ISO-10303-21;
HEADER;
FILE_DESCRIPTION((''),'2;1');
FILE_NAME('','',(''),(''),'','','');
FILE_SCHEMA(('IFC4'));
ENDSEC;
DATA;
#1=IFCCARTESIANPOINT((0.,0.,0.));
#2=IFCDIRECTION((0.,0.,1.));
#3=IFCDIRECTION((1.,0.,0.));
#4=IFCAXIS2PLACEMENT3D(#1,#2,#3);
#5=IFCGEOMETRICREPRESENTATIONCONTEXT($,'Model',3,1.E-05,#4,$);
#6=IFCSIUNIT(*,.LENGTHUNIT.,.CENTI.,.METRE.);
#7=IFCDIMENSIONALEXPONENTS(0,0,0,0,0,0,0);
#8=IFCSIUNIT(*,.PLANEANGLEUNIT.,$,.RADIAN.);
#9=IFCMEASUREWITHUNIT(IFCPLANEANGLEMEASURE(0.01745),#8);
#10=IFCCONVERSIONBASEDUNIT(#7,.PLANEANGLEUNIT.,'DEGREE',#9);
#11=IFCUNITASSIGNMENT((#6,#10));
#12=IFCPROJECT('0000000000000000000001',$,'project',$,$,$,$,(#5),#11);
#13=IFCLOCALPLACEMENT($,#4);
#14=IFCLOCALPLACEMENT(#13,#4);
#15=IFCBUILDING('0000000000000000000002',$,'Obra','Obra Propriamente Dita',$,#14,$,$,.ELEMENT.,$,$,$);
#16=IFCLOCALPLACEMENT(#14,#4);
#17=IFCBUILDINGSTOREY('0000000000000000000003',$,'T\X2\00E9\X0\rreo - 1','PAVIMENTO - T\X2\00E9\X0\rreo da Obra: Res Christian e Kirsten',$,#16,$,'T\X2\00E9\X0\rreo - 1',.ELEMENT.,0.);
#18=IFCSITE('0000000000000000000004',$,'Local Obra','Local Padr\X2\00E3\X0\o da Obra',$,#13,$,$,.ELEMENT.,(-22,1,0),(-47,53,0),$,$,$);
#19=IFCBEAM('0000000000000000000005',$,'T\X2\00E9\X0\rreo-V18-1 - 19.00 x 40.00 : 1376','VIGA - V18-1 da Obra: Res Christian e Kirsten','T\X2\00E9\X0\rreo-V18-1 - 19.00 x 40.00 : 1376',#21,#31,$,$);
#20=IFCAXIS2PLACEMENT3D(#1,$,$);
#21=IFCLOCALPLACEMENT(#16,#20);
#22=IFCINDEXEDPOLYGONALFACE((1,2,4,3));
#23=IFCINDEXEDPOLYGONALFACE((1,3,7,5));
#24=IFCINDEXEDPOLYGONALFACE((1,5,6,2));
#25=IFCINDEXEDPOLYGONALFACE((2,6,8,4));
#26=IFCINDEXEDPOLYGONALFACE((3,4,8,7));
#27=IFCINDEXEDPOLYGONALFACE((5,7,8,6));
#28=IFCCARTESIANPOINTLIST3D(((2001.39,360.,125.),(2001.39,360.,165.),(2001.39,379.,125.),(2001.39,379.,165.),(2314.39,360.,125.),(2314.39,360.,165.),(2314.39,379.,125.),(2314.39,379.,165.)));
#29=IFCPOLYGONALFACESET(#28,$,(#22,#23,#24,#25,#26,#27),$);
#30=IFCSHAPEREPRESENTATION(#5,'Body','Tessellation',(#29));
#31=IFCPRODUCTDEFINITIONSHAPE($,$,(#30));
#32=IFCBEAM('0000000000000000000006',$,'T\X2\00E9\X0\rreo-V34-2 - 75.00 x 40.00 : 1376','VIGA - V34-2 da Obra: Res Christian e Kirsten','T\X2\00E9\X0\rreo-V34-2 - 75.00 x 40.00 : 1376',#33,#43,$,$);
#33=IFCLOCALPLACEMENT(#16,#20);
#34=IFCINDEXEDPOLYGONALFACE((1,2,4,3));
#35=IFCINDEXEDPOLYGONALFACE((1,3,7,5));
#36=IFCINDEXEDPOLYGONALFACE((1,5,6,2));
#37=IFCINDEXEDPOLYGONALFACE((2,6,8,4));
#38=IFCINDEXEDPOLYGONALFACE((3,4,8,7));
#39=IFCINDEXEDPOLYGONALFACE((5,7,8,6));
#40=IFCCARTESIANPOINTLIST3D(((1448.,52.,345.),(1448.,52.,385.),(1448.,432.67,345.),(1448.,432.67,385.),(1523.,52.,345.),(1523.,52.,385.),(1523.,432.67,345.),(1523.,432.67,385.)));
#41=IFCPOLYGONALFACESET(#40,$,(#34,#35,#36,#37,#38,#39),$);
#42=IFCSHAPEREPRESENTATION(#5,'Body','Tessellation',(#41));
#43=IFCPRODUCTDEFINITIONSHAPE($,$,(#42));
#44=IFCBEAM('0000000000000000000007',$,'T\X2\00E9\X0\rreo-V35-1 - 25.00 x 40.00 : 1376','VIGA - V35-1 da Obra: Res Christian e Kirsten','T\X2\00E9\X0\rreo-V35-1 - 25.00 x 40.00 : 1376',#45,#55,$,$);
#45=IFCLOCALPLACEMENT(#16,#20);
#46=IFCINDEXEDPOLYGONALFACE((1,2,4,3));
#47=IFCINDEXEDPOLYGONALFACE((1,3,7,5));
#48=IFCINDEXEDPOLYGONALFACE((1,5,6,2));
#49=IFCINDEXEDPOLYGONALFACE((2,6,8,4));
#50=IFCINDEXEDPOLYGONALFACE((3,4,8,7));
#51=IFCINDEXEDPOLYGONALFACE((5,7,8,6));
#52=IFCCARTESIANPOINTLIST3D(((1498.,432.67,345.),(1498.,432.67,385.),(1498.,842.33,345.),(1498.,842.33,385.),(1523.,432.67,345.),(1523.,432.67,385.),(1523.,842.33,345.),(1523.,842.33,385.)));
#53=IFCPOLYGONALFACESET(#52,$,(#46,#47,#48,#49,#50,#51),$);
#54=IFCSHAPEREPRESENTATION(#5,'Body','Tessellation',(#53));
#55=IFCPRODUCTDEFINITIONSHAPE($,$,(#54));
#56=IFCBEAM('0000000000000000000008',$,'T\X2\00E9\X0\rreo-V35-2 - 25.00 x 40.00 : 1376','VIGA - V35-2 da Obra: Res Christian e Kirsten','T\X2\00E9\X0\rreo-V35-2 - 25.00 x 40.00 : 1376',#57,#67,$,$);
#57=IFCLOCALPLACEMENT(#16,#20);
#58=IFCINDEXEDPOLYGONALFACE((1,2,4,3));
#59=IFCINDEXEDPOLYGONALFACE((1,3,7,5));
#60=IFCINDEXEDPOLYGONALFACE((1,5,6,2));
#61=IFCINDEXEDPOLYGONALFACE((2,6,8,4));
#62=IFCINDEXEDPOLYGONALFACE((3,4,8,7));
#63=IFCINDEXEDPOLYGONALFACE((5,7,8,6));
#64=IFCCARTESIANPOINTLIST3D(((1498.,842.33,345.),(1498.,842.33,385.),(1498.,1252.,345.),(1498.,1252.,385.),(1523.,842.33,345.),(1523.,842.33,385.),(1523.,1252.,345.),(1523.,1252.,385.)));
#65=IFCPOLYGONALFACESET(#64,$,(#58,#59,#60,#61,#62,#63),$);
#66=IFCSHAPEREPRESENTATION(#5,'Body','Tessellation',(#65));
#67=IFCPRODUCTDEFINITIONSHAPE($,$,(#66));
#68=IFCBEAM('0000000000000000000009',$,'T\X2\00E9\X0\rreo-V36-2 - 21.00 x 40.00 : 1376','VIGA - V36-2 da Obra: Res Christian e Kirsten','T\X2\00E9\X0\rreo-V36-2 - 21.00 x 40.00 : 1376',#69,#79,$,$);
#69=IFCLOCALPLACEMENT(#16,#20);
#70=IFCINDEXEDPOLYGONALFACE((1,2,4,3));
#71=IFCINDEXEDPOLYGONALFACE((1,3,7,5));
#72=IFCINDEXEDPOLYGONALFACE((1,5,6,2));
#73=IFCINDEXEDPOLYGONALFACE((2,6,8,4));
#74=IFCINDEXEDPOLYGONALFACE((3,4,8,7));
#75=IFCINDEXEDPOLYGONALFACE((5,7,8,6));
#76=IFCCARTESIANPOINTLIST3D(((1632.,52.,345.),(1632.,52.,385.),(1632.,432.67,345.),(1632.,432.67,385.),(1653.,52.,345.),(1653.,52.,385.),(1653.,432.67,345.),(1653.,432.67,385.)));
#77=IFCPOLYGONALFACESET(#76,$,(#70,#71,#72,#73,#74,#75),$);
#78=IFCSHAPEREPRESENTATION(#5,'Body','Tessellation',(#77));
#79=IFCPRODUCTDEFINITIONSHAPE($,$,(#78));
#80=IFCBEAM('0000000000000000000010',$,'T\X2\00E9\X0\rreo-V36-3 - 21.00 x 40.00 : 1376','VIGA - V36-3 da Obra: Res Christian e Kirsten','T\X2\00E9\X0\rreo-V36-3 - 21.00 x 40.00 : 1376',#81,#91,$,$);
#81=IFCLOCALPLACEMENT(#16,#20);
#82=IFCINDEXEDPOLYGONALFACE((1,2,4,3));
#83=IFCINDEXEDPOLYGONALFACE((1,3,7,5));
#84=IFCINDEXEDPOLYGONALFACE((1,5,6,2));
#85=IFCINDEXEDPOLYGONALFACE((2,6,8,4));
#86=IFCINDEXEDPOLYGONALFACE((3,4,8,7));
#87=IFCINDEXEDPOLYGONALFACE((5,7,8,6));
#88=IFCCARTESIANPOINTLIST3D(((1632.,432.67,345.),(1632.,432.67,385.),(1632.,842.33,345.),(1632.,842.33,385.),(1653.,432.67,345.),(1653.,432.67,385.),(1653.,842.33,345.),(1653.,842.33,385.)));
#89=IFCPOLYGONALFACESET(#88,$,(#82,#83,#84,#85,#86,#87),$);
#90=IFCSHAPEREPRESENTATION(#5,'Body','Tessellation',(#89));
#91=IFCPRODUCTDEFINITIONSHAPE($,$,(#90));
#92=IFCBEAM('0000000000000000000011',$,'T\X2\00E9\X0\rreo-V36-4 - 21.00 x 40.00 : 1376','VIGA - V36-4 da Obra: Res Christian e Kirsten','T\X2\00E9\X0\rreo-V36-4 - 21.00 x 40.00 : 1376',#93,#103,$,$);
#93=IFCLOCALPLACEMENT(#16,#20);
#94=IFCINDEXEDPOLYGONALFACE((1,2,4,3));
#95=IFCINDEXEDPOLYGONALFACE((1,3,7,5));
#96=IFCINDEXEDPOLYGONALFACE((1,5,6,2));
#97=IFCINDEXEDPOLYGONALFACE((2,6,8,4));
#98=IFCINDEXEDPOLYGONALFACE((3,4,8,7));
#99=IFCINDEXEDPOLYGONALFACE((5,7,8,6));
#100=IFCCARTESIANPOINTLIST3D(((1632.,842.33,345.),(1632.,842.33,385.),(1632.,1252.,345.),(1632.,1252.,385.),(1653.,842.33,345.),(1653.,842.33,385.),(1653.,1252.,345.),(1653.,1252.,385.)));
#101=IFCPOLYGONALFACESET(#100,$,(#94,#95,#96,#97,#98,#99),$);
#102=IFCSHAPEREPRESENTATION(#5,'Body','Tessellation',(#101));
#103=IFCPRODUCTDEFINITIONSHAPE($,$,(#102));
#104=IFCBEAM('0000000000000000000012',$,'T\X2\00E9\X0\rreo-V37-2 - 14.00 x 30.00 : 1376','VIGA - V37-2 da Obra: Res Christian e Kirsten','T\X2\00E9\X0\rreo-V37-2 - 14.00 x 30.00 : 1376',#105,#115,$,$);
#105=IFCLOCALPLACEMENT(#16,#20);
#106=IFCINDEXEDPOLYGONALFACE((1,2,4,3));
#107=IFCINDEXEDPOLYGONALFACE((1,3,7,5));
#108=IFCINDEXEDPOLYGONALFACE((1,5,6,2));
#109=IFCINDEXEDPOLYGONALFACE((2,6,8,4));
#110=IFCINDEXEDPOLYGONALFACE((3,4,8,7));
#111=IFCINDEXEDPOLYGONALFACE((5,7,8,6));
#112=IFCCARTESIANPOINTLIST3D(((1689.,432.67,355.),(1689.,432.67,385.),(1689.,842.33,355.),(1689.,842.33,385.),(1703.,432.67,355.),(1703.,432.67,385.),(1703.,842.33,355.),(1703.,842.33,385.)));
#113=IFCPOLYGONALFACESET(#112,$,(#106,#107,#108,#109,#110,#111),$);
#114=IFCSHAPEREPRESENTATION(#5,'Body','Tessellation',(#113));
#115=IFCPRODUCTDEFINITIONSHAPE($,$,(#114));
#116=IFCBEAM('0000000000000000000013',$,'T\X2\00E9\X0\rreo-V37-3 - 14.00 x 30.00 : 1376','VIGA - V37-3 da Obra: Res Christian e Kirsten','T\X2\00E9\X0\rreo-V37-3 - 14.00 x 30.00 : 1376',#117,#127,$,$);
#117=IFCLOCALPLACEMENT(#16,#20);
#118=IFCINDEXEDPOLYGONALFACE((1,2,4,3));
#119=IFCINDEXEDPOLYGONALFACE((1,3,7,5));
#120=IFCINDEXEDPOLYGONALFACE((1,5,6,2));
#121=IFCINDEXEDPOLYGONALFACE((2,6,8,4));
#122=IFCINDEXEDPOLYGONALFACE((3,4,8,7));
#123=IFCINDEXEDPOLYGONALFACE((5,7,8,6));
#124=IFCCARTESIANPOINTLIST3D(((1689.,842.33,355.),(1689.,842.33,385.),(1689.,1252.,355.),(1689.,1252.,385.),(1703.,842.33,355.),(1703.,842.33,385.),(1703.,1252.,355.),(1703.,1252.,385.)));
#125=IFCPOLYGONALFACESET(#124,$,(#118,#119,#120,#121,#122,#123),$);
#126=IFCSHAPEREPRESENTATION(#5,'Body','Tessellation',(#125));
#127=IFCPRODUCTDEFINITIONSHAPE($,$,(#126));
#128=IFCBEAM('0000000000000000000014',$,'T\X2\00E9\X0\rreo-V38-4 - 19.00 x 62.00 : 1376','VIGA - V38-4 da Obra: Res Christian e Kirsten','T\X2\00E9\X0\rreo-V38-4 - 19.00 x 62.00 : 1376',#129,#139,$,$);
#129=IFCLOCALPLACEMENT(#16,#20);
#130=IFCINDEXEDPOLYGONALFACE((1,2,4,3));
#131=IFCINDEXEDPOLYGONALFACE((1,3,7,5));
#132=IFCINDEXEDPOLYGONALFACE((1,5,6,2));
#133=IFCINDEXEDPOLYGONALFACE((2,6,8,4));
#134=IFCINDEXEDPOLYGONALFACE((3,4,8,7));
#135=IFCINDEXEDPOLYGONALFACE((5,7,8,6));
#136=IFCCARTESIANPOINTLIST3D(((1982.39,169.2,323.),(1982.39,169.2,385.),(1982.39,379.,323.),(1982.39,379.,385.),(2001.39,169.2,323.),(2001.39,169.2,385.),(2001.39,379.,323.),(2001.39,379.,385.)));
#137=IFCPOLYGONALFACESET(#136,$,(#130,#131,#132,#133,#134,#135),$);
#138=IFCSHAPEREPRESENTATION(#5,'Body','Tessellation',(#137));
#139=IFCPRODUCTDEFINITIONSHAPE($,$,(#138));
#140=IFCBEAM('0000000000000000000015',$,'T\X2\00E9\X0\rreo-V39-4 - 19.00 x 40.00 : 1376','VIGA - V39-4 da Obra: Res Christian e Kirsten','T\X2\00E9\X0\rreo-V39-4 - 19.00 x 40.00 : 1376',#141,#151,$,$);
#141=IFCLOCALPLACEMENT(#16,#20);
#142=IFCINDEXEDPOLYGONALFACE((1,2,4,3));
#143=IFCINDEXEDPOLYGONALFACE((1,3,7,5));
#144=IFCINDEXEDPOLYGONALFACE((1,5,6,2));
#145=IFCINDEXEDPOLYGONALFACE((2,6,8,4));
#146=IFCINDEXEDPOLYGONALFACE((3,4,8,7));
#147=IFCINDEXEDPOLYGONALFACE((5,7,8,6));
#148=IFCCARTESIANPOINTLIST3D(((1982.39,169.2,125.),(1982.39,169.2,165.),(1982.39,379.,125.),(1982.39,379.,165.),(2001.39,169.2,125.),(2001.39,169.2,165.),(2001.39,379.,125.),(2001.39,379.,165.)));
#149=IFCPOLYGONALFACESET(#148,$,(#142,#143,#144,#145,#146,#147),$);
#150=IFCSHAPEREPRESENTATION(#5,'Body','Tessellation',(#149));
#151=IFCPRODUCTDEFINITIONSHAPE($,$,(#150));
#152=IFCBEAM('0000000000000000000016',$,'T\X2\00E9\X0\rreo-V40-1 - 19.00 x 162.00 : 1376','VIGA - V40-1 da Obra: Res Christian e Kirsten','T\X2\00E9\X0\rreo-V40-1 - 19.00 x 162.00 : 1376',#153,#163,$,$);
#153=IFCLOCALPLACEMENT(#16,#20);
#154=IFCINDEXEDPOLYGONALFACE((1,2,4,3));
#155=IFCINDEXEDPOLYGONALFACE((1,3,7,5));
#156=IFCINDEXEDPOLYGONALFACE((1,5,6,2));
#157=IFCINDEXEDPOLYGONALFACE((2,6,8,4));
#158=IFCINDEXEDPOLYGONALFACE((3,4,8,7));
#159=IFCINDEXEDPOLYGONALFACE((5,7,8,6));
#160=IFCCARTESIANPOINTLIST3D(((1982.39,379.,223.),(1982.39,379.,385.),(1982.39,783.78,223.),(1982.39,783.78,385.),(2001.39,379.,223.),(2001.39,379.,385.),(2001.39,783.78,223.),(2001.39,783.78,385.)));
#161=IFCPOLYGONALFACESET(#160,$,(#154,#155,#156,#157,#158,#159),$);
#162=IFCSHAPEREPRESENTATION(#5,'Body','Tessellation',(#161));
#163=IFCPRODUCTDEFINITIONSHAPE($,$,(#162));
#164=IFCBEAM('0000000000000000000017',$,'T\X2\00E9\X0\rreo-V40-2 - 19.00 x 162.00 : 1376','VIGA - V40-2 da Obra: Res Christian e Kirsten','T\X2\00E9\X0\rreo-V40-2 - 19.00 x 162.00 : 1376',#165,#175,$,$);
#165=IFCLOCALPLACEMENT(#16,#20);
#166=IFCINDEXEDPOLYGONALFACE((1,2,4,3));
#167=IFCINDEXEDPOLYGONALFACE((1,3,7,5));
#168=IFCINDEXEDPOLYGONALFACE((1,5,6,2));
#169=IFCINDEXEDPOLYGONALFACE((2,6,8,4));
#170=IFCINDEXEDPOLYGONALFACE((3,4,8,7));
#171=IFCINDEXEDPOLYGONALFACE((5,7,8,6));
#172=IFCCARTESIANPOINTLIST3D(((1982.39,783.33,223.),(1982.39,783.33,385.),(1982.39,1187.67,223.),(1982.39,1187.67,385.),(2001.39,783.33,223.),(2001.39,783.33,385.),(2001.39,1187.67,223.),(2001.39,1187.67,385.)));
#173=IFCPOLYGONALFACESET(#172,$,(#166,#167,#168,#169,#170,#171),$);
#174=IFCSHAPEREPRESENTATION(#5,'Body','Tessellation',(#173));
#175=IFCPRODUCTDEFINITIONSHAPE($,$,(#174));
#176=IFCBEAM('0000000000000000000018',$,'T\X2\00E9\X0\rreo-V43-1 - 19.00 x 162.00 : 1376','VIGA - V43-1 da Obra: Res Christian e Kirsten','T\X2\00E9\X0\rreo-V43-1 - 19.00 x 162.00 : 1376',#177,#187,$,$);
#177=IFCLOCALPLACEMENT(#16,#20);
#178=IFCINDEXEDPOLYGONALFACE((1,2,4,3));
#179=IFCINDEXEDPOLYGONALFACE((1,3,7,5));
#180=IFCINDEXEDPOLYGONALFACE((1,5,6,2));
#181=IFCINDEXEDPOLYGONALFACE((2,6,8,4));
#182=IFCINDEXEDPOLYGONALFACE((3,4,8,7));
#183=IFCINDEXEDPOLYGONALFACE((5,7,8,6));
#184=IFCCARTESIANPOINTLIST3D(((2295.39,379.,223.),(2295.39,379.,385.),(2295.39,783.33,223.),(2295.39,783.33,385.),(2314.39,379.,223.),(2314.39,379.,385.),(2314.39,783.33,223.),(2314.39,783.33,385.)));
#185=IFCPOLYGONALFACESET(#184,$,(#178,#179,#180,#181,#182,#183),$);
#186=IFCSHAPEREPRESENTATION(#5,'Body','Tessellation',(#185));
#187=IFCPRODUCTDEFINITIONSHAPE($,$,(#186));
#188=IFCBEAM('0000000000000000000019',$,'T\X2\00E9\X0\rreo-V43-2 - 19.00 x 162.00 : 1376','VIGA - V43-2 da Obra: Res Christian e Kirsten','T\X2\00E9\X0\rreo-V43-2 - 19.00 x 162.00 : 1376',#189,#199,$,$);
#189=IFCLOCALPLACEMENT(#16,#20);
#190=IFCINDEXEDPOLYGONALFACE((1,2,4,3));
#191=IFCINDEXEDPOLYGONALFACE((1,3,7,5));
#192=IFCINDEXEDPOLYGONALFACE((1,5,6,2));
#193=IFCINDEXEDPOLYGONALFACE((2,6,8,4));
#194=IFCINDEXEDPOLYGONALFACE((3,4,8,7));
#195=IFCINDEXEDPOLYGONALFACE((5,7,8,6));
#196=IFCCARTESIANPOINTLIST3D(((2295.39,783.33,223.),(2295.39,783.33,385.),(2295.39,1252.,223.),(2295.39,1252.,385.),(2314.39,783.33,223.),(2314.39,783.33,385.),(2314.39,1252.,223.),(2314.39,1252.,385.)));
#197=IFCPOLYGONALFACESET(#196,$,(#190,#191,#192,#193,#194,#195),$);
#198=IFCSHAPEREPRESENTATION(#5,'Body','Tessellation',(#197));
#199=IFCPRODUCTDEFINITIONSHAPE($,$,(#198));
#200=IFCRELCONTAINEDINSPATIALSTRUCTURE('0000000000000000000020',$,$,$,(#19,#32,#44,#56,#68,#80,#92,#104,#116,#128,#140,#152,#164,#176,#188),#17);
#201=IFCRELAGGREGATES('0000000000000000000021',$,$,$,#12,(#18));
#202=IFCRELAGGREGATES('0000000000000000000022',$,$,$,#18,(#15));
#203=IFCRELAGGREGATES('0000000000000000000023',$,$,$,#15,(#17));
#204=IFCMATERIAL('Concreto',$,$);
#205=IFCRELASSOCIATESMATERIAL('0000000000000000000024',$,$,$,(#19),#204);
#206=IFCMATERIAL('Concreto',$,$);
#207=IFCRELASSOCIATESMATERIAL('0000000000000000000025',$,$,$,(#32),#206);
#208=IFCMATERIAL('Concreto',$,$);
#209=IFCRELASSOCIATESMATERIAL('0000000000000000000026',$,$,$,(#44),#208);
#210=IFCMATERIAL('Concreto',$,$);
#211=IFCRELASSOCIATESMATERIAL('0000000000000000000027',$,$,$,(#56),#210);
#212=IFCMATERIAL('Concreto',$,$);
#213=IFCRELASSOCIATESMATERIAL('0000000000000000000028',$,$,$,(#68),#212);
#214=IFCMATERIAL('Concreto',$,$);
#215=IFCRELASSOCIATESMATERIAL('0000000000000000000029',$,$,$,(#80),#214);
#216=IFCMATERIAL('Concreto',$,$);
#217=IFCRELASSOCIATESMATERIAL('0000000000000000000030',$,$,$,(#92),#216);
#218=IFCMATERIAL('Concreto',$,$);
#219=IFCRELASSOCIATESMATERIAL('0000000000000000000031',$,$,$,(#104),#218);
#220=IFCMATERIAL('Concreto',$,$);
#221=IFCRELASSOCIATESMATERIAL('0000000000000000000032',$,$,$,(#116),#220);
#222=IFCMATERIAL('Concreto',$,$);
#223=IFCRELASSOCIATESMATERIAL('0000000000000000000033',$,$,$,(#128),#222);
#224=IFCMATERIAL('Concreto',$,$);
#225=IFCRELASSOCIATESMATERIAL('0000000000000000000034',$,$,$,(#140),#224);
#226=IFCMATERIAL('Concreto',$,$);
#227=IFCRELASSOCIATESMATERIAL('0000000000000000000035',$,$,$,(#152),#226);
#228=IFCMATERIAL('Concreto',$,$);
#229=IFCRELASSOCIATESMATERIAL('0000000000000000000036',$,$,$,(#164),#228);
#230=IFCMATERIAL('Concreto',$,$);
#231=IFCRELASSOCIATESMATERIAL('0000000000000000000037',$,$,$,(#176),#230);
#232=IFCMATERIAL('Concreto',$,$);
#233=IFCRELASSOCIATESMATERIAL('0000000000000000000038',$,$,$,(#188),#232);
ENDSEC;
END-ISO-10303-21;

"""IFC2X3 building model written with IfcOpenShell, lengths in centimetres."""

from ifc_helpers import new_model, entity, si_unit, converted_unit, frame, origin_with_axes, place, context, project, spatial, polyline, outline, extrude, material, element, save


model = new_model("IFC2X3")

# Units and contexts
model_context = context("Model", 3, precision=1e-05, world=origin_with_axes())
ifc_project = project(units=[si_unit("LENGTHUNIT", "METRE", prefix="CENTI"), converted_unit("PLANEANGLEUNIT", "DEGREE", entity("IfcPlaneAngleMeasure", 0.01745), si_unit("PLANEANGLEUNIT", "RADIAN"), dimensions=[0, 0, 0, 0, 0, 0, 0])], contexts=[model_context])

# Site, building, storey
site_placement = place(None, origin_with_axes())
site = spatial("IfcSite", under=ifc_project, at=site_placement, Name="Local Obra", Description="Local Padrão da Obra", CompositionType="ELEMENT", RefLatitude=(-22, 1, 0), RefLongitude=(-47, 53, 0))
building_placement = place(site_placement, origin_with_axes())
building = spatial("IfcBuilding", under=site, at=building_placement, Name="Obra", Description="Obra Propriamente Dita", CompositionType="ELEMENT")
storey_placement = place(building_placement, origin_with_axes())
storey = spatial("IfcBuildingStorey", under=building, at=storey_placement, Name="Térreo - 1", Description="PAVIMENTO - Térreo da Obra: Res Christian e Kirsten", LongName="Térreo - 1", CompositionType="ELEMENT", Elevation=0.0)

# Beams
ifc_material_1 = material(Name="Concreto")
beam_1_placement = place(storey_placement, frame((2001.39, 379.0, 165.0), z_axis=(1.0, 0.0, 0.0), x_axis=(0.0, -1.0, 0.0)))
element("IfcBeam", 1, at=beam_1_placement, inside=storey, material=ifc_material_1, Name="Térreo-V18-1 - 19.00 x 40.00 : 1376", Description="VIGA - V18-1 da Obra: Res Christian e Kirsten", ObjectType="Térreo-V18-1 - 19.00 x 40.00 : 1376", context=model_context, shape_type="SweptSolid", body=[
    extrude(outline(polyline([(0.0, 0.0), (19.0, 0.0), (19.0, 40.0), (0.0, 40.0), (0.0, 0.0)])), origin_with_axes(), (0.0, 0.0, 1.0), 313.0),
])
ifc_material_2 = material(Name="Concreto")
beam_2_placement = place(storey_placement, frame((1523.0, 52.0, 385.0), z_axis=(0.0, 1.0, 0.0), x_axis=(1.0, 0.0, 0.0)))
element("IfcBeam", 2, at=beam_2_placement, inside=storey, material=ifc_material_2, Name="Térreo-V34-2 - 75.00 x 40.00 : 1376", Description="VIGA - V34-2 da Obra: Res Christian e Kirsten", ObjectType="Térreo-V34-2 - 75.00 x 40.00 : 1376", context=model_context, shape_type="SweptSolid", body=[
    extrude(outline(polyline([(-75.0, 0.0), (0.0, 0.0), (0.0, 40.0), (-75.0, 40.0), (-75.0, 0.0)])), origin_with_axes(), (0.0, 0.0, 1.0), 380.67),
])
ifc_material_3 = material(Name="Concreto")
beam_3_placement = place(storey_placement, frame((1523.0, 432.67, 385.0), z_axis=(0.0, 1.0, 0.0), x_axis=(1.0, 0.0, 0.0)))
element("IfcBeam", 3, at=beam_3_placement, inside=storey, material=ifc_material_3, Name="Térreo-V35-1 - 25.00 x 40.00 : 1376", Description="VIGA - V35-1 da Obra: Res Christian e Kirsten", ObjectType="Térreo-V35-1 - 25.00 x 40.00 : 1376", context=model_context, shape_type="SweptSolid", body=[
    extrude(outline(polyline([(-25.0, 0.0), (0.0, 0.0), (0.0, 40.0), (-25.0, 40.0), (-25.0, 0.0)])), origin_with_axes(), (0.0, 0.0, 1.0), 409.67),
])
ifc_material_4 = material(Name="Concreto")
beam_4_placement = place(storey_placement, frame((1523.0, 842.33, 385.0), z_axis=(0.0, 1.0, 0.0), x_axis=(1.0, 0.0, 0.0)))
element("IfcBeam", 4, at=beam_4_placement, inside=storey, material=ifc_material_4, Name="Térreo-V35-2 - 25.00 x 40.00 : 1376", Description="VIGA - V35-2 da Obra: Res Christian e Kirsten", ObjectType="Térreo-V35-2 - 25.00 x 40.00 : 1376", context=model_context, shape_type="SweptSolid", body=[
    extrude(outline(polyline([(-25.0, 0.0), (0.0, 0.0), (0.0, 40.0), (-25.0, 40.0), (-25.0, 0.0)])), origin_with_axes(), (0.0, 0.0, 1.0), 409.67),
])
ifc_material_5 = material(Name="Concreto")
beam_5_placement = place(storey_placement, frame((1653.0, 52.0, 385.0), z_axis=(0.0, 1.0, 0.0), x_axis=(1.0, 0.0, 0.0)))
element("IfcBeam", 5, at=beam_5_placement, inside=storey, material=ifc_material_5, Name="Térreo-V36-2 - 21.00 x 40.00 : 1376", Description="VIGA - V36-2 da Obra: Res Christian e Kirsten", ObjectType="Térreo-V36-2 - 21.00 x 40.00 : 1376", context=model_context, shape_type="SweptSolid", body=[
    extrude(outline(polyline([(-21.0, 0.0), (0.0, 0.0), (0.0, 40.0), (-21.0, 40.0), (-21.0, 0.0)])), origin_with_axes(), (0.0, 0.0, 1.0), 380.67),
])
ifc_material_6 = material(Name="Concreto")
beam_6_placement = place(storey_placement, frame((1653.0, 432.67, 385.0), z_axis=(0.0, 1.0, 0.0), x_axis=(1.0, 0.0, 0.0)))
element("IfcBeam", 6, at=beam_6_placement, inside=storey, material=ifc_material_6, Name="Térreo-V36-3 - 21.00 x 40.00 : 1376", Description="VIGA - V36-3 da Obra: Res Christian e Kirsten", ObjectType="Térreo-V36-3 - 21.00 x 40.00 : 1376", context=model_context, shape_type="SweptSolid", body=[
    extrude(outline(polyline([(-21.0, 0.0), (0.0, 0.0), (0.0, 40.0), (-21.0, 40.0), (-21.0, 0.0)])), origin_with_axes(), (0.0, 0.0, 1.0), 409.67),
])
ifc_material_7 = material(Name="Concreto")
beam_7_placement = place(storey_placement, frame((1653.0, 842.33, 385.0), z_axis=(0.0, 1.0, 0.0), x_axis=(1.0, 0.0, 0.0)))
element("IfcBeam", 7, at=beam_7_placement, inside=storey, material=ifc_material_7, Name="Térreo-V36-4 - 21.00 x 40.00 : 1376", Description="VIGA - V36-4 da Obra: Res Christian e Kirsten", ObjectType="Térreo-V36-4 - 21.00 x 40.00 : 1376", context=model_context, shape_type="SweptSolid", body=[
    extrude(outline(polyline([(-21.0, 0.0), (0.0, 0.0), (0.0, 40.0), (-21.0, 40.0), (-21.0, 0.0)])), origin_with_axes(), (0.0, 0.0, 1.0), 409.67),
])
ifc_material_8 = material(Name="Concreto")
beam_8_placement = place(storey_placement, frame((1703.0, 432.67, 385.0), z_axis=(0.0, 1.0, 0.0), x_axis=(1.0, 0.0, 0.0)))
element("IfcBeam", 8, at=beam_8_placement, inside=storey, material=ifc_material_8, Name="Térreo-V37-2 - 14.00 x 30.00 : 1376", Description="VIGA - V37-2 da Obra: Res Christian e Kirsten", ObjectType="Térreo-V37-2 - 14.00 x 30.00 : 1376", context=model_context, shape_type="SweptSolid", body=[
    extrude(outline(polyline([(-14.0, 0.0), (0.0, 0.0), (0.0, 30.0), (-14.0, 30.0), (-14.0, 0.0)])), origin_with_axes(), (0.0, 0.0, 1.0), 409.66),
])
ifc_material_9 = material(Name="Concreto")
beam_9_placement = place(storey_placement, frame((1703.0, 842.33, 385.0), z_axis=(0.0, 1.0, 0.0), x_axis=(1.0, 0.0, 0.0)))
element("IfcBeam", 9, at=beam_9_placement, inside=storey, material=ifc_material_9, Name="Térreo-V37-3 - 14.00 x 30.00 : 1376", Description="VIGA - V37-3 da Obra: Res Christian e Kirsten", ObjectType="Térreo-V37-3 - 14.00 x 30.00 : 1376", context=model_context, shape_type="SweptSolid", body=[
    extrude(outline(polyline([(-14.0, 0.0), (0.0, 0.0), (0.0, 30.0), (-14.0, 30.0), (-14.0, 0.0)])), origin_with_axes(), (0.0, 0.0, 1.0), 409.67),
])
ifc_material_10 = material(Name="Concreto")
beam_10_placement = place(storey_placement, frame((2001.39, 169.2, 385.0), z_axis=(0.0, 1.0, 0.0), x_axis=(1.0, 0.0, 0.0)))
element("IfcBeam", 10, at=beam_10_placement, inside=storey, material=ifc_material_10, Name="Térreo-V38-4 - 19.00 x 62.00 : 1376", Description="VIGA - V38-4 da Obra: Res Christian e Kirsten", ObjectType="Térreo-V38-4 - 19.00 x 62.00 : 1376", context=model_context, shape_type="SweptSolid", body=[
    extrude(outline(polyline([(-19.0, 0.0), (0.0, 0.0), (0.0, 62.0), (-19.0, 62.0), (-19.0, 0.0)])), origin_with_axes(), (0.0, 0.0, 1.0), 209.8),
])
ifc_material_11 = material(Name="Concreto")
beam_11_placement = place(storey_placement, frame((2001.39, 169.2, 165.0), z_axis=(0.0, 1.0, 0.0), x_axis=(1.0, 0.0, 0.0)))
element("IfcBeam", 11, at=beam_11_placement, inside=storey, material=ifc_material_11, Name="Térreo-V39-4 - 19.00 x 40.00 : 1376", Description="VIGA - V39-4 da Obra: Res Christian e Kirsten", ObjectType="Térreo-V39-4 - 19.00 x 40.00 : 1376", context=model_context, shape_type="SweptSolid", body=[
    extrude(outline(polyline([(-19.0, 0.0), (0.0, 0.0), (0.0, 40.0), (-19.0, 40.0), (-19.0, 0.0)])), origin_with_axes(), (0.0, 0.0, 1.0), 209.8),
])
ifc_material_12 = material(Name="Concreto")
beam_12_placement = place(storey_placement, frame((2001.39, 379.0, 385.0), z_axis=(0.0, 1.0, 0.0), x_axis=(1.0, 0.0, 0.0)))
element("IfcBeam", 12, at=beam_12_placement, inside=storey, material=ifc_material_12, Name="Térreo-V40-1 - 19.00 x 162.00 : 1376", Description="VIGA - V40-1 da Obra: Res Christian e Kirsten", ObjectType="Térreo-V40-1 - 19.00 x 162.00 : 1376", context=model_context, shape_type="SweptSolid", body=[
    extrude(outline(polyline([(-19.0, 0.0), (0.0, 0.0), (0.0, 162.0), (-19.0, 162.0), (-19.0, 0.0)])), origin_with_axes(), (0.0, 0.0, 1.0), 404.78),
])
ifc_material_13 = material(Name="Concreto")
beam_13_placement = place(storey_placement, frame((1982.39, 783.33, 385.0), z_axis=(0.0, 1.0, 0.0), x_axis=(1.0, 0.0, 0.0)))
element("IfcBeam", 13, at=beam_13_placement, inside=storey, material=ifc_material_13, Name="Térreo-V40-2 - 19.00 x 162.00 : 1376", Description="VIGA - V40-2 da Obra: Res Christian e Kirsten", ObjectType="Térreo-V40-2 - 19.00 x 162.00 : 1376", context=model_context, shape_type="SweptSolid", body=[
    extrude(outline(polyline([(0.0, 0.0), (19.0, 0.0), (19.0, 162.0), (0.0, 162.0), (0.0, 0.0)])), origin_with_axes(), (0.0, 0.0, 1.0), 404.33),
])
ifc_material_14 = material(Name="Concreto")
beam_14_placement = place(storey_placement, frame((2314.39, 379.0, 385.0), z_axis=(0.000002, 1.0, 0.0), x_axis=(1.0, -0.000002, 0.0)))
element("IfcBeam", 14, at=beam_14_placement, inside=storey, material=ifc_material_14, Name="Térreo-V43-1 - 19.00 x 162.00 : 1376", Description="VIGA - V43-1 da Obra: Res Christian e Kirsten", ObjectType="Térreo-V43-1 - 19.00 x 162.00 : 1376", context=model_context, shape_type="SweptSolid", body=[
    extrude(outline(polyline([(-19.0, 0.0), (0.0, 0.0), (0.0, 162.0), (-19.0, 162.0), (-19.0, 0.0)])), origin_with_axes(), (0.0, 0.0, 1.0), 404.33),
])
ifc_material_15 = material(Name="Concreto")
beam_15_placement = place(storey_placement, frame((2314.39, 783.33, 385.0), z_axis=(0.0, 1.0, 0.0), x_axis=(1.0, 0.0, 0.0)))
element("IfcBeam", 15, at=beam_15_placement, inside=storey, material=ifc_material_15, Name="Térreo-V43-2 - 19.00 x 162.00 : 1376", Description="VIGA - V43-2 da Obra: Res Christian e Kirsten", ObjectType="Térreo-V43-2 - 19.00 x 162.00 : 1376", context=model_context, shape_type="SweptSolid", body=[
    extrude(outline(polyline([(-19.0, 0.0), (0.0, 0.0), (0.0, 162.0), (-19.0, 162.0), (-19.0, 0.0)])), origin_with_axes(), (0.0, 0.0, 1.0), 468.67),
])

save(model, "model.ifc")
